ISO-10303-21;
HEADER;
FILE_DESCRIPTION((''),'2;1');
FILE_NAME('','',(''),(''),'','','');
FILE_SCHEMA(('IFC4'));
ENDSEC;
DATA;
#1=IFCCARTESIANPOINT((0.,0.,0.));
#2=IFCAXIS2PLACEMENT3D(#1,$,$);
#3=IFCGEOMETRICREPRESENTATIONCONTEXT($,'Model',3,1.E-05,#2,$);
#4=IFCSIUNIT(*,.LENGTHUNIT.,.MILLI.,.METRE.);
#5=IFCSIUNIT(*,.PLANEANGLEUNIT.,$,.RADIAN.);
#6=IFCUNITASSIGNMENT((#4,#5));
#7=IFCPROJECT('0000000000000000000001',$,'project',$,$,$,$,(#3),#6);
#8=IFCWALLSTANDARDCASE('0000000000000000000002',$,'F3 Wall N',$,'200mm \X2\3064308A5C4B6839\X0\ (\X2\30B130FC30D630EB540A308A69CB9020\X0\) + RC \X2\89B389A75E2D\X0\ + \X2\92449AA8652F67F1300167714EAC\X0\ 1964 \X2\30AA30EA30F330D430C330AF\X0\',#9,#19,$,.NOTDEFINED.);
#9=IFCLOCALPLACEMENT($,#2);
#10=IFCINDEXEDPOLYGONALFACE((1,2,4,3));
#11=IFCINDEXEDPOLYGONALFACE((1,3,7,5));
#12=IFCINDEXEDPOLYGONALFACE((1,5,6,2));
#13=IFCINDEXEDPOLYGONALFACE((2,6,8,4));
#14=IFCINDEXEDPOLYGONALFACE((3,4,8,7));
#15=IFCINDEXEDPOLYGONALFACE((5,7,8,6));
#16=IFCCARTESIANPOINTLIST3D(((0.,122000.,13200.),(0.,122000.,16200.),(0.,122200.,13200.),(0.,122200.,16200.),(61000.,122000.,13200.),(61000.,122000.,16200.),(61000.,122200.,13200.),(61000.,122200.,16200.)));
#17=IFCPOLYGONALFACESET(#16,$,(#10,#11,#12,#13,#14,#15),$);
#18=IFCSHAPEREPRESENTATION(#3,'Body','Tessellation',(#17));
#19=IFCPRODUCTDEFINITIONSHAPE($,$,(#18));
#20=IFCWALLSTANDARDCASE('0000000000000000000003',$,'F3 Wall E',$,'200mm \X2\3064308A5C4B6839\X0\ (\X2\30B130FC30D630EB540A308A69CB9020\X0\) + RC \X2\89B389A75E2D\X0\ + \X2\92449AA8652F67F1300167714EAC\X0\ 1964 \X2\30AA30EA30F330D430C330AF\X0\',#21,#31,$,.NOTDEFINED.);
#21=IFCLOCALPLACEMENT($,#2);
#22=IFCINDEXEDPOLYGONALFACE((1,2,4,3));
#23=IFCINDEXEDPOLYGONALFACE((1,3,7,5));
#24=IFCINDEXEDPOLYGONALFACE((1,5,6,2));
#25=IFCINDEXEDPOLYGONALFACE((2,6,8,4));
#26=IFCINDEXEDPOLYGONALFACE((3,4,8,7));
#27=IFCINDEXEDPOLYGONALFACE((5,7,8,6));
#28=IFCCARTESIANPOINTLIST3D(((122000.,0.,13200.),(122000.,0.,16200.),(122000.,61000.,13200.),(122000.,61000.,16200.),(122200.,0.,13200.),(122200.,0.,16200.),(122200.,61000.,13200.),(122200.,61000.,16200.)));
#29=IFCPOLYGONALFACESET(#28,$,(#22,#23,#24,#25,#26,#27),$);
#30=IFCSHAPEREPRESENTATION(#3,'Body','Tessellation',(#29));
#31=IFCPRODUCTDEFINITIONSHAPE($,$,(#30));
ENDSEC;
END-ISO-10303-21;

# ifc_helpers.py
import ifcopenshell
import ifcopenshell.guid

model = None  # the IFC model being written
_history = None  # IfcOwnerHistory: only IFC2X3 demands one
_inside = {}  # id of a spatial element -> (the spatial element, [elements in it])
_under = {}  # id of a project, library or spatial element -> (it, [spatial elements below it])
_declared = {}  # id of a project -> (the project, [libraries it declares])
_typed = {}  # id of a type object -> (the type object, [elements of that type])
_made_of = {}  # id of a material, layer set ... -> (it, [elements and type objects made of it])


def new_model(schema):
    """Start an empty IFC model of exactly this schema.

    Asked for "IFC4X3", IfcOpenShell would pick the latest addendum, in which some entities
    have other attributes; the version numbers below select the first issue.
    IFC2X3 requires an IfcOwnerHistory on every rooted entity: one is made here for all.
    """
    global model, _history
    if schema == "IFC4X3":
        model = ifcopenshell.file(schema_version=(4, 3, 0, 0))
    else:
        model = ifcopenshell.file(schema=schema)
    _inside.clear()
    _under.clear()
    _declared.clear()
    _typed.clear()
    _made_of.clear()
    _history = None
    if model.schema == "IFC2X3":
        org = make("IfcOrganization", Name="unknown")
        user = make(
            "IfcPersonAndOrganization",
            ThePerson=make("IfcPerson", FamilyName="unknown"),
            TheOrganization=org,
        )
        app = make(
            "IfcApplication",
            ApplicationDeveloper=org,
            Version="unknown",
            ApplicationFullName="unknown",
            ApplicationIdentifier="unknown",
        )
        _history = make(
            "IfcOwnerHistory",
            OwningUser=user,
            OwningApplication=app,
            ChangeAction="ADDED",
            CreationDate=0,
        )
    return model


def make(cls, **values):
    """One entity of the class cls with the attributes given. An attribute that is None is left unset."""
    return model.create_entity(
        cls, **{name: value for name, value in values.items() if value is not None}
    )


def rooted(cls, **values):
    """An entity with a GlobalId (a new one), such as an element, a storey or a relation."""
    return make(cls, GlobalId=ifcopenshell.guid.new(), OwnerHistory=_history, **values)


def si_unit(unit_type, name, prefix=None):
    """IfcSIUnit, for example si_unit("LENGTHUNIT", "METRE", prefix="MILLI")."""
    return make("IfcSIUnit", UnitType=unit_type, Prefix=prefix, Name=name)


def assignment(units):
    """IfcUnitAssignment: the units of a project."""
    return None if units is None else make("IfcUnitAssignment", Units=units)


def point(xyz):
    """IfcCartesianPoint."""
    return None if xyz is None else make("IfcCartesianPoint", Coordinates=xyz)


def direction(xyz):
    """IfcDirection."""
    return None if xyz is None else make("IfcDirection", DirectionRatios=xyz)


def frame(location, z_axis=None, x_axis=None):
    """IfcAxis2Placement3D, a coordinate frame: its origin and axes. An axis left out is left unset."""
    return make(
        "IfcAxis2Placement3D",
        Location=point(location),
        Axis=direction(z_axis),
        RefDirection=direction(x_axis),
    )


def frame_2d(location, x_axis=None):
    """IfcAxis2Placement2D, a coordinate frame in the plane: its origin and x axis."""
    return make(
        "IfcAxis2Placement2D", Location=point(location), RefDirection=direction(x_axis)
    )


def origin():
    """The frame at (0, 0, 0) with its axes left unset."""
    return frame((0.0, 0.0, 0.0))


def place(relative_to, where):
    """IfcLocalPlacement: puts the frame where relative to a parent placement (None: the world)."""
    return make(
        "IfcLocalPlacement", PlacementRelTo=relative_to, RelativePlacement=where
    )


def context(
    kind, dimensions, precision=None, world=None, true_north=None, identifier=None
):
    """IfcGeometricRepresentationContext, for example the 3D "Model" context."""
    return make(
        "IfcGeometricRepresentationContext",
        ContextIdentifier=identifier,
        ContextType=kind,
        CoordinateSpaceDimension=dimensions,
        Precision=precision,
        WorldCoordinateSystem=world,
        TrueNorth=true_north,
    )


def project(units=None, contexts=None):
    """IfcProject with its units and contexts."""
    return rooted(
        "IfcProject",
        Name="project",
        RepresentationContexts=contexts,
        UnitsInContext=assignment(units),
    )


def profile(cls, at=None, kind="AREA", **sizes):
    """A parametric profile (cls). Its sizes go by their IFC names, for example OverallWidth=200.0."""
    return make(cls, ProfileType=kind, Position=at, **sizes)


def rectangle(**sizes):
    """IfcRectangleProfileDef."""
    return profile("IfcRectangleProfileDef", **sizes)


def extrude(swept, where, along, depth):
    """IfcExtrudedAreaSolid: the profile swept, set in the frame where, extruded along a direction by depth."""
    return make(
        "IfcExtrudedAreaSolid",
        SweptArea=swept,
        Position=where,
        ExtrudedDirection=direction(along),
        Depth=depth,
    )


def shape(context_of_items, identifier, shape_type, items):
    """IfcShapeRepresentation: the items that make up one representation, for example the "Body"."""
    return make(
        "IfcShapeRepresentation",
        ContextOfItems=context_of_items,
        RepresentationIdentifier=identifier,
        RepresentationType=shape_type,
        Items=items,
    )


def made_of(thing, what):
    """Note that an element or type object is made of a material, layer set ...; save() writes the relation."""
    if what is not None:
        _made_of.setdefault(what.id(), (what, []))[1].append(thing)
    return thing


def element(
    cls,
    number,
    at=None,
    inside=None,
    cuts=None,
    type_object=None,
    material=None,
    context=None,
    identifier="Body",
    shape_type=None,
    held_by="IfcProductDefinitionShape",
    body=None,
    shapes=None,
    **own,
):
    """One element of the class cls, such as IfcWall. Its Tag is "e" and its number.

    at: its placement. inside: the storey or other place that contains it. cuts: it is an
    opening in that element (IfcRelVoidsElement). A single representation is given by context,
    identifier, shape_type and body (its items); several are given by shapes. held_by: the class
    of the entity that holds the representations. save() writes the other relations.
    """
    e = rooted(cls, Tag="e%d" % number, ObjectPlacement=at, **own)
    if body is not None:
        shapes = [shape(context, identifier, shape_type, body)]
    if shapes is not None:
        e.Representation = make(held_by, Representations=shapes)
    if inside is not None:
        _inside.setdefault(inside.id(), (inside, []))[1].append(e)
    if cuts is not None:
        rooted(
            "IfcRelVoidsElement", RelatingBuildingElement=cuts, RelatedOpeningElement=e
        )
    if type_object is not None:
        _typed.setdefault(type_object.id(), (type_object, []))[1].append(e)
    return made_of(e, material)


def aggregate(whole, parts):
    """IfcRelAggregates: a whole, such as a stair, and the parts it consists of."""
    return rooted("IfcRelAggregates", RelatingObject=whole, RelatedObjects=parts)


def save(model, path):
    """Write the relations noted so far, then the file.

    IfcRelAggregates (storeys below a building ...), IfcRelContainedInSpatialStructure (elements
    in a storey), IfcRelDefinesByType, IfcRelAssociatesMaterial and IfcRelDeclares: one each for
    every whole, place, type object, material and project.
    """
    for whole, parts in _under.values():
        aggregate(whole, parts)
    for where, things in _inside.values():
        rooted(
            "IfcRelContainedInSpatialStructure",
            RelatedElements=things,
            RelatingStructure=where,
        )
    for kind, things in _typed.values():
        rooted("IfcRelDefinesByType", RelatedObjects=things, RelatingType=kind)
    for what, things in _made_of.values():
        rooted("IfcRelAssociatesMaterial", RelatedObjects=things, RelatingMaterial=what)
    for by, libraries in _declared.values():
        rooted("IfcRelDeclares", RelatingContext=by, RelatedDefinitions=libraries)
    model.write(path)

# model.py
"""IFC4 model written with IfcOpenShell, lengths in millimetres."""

from ifc_helpers import new_model, si_unit, frame, frame_2d, origin, place, context, project, rectangle, extrude, element, save


model = new_model("IFC4")

# Units and contexts
model_context = context("Model", 3, precision=1e-05, world=origin())
ifc_project = project(units=[si_unit("LENGTHUNIT", "METRE", prefix="MILLI"), si_unit("PLANEANGLEUNIT", "RADIAN")], contexts=[model_context])

# Shared definitions
placement_1 = place(None, origin())
placement_2 = place(placement_1, origin())
placement_3 = place(placement_2, origin())

# Walls
wall_1_placement = place(placement_3, frame((0.0, 61000.0, 6600.0)))
element("IfcWallStandardCase", 1, at=wall_1_placement, Name="F3 Wall N", ObjectType="200mm つり屋根 (ケーブル吊り構造) + RC 観覧席 + 鉄骨支柱、東京 1964 オリンピック", PredefinedType="NOTDEFINED", context=model_context, shape_type="SweptSolid", body=[
    extrude(rectangle(XDim=61000.0, YDim=200.0, at=frame_2d((30500.0, 100.0))), frame((0.0, 61000.0, 6600.0)), (0.0, 0.0, 1.0), 3000.0),
])
wall_2_placement = place(placement_3, frame((61000.0, 0.0, 6600.0)))
element("IfcWallStandardCase", 2, at=wall_2_placement, Name="F3 Wall E", ObjectType="200mm つり屋根 (ケーブル吊り構造) + RC 観覧席 + 鉄骨支柱、東京 1964 オリンピック", PredefinedType="NOTDEFINED", context=model_context, shape_type="SweptSolid", body=[
    extrude(rectangle(XDim=200.0, YDim=61000.0, at=frame_2d((100.0, 30500.0))), frame((61000.0, 0.0, 6600.0)), (0.0, 0.0, 1.0), 3000.0),
])

save(model, "model.ifc")
